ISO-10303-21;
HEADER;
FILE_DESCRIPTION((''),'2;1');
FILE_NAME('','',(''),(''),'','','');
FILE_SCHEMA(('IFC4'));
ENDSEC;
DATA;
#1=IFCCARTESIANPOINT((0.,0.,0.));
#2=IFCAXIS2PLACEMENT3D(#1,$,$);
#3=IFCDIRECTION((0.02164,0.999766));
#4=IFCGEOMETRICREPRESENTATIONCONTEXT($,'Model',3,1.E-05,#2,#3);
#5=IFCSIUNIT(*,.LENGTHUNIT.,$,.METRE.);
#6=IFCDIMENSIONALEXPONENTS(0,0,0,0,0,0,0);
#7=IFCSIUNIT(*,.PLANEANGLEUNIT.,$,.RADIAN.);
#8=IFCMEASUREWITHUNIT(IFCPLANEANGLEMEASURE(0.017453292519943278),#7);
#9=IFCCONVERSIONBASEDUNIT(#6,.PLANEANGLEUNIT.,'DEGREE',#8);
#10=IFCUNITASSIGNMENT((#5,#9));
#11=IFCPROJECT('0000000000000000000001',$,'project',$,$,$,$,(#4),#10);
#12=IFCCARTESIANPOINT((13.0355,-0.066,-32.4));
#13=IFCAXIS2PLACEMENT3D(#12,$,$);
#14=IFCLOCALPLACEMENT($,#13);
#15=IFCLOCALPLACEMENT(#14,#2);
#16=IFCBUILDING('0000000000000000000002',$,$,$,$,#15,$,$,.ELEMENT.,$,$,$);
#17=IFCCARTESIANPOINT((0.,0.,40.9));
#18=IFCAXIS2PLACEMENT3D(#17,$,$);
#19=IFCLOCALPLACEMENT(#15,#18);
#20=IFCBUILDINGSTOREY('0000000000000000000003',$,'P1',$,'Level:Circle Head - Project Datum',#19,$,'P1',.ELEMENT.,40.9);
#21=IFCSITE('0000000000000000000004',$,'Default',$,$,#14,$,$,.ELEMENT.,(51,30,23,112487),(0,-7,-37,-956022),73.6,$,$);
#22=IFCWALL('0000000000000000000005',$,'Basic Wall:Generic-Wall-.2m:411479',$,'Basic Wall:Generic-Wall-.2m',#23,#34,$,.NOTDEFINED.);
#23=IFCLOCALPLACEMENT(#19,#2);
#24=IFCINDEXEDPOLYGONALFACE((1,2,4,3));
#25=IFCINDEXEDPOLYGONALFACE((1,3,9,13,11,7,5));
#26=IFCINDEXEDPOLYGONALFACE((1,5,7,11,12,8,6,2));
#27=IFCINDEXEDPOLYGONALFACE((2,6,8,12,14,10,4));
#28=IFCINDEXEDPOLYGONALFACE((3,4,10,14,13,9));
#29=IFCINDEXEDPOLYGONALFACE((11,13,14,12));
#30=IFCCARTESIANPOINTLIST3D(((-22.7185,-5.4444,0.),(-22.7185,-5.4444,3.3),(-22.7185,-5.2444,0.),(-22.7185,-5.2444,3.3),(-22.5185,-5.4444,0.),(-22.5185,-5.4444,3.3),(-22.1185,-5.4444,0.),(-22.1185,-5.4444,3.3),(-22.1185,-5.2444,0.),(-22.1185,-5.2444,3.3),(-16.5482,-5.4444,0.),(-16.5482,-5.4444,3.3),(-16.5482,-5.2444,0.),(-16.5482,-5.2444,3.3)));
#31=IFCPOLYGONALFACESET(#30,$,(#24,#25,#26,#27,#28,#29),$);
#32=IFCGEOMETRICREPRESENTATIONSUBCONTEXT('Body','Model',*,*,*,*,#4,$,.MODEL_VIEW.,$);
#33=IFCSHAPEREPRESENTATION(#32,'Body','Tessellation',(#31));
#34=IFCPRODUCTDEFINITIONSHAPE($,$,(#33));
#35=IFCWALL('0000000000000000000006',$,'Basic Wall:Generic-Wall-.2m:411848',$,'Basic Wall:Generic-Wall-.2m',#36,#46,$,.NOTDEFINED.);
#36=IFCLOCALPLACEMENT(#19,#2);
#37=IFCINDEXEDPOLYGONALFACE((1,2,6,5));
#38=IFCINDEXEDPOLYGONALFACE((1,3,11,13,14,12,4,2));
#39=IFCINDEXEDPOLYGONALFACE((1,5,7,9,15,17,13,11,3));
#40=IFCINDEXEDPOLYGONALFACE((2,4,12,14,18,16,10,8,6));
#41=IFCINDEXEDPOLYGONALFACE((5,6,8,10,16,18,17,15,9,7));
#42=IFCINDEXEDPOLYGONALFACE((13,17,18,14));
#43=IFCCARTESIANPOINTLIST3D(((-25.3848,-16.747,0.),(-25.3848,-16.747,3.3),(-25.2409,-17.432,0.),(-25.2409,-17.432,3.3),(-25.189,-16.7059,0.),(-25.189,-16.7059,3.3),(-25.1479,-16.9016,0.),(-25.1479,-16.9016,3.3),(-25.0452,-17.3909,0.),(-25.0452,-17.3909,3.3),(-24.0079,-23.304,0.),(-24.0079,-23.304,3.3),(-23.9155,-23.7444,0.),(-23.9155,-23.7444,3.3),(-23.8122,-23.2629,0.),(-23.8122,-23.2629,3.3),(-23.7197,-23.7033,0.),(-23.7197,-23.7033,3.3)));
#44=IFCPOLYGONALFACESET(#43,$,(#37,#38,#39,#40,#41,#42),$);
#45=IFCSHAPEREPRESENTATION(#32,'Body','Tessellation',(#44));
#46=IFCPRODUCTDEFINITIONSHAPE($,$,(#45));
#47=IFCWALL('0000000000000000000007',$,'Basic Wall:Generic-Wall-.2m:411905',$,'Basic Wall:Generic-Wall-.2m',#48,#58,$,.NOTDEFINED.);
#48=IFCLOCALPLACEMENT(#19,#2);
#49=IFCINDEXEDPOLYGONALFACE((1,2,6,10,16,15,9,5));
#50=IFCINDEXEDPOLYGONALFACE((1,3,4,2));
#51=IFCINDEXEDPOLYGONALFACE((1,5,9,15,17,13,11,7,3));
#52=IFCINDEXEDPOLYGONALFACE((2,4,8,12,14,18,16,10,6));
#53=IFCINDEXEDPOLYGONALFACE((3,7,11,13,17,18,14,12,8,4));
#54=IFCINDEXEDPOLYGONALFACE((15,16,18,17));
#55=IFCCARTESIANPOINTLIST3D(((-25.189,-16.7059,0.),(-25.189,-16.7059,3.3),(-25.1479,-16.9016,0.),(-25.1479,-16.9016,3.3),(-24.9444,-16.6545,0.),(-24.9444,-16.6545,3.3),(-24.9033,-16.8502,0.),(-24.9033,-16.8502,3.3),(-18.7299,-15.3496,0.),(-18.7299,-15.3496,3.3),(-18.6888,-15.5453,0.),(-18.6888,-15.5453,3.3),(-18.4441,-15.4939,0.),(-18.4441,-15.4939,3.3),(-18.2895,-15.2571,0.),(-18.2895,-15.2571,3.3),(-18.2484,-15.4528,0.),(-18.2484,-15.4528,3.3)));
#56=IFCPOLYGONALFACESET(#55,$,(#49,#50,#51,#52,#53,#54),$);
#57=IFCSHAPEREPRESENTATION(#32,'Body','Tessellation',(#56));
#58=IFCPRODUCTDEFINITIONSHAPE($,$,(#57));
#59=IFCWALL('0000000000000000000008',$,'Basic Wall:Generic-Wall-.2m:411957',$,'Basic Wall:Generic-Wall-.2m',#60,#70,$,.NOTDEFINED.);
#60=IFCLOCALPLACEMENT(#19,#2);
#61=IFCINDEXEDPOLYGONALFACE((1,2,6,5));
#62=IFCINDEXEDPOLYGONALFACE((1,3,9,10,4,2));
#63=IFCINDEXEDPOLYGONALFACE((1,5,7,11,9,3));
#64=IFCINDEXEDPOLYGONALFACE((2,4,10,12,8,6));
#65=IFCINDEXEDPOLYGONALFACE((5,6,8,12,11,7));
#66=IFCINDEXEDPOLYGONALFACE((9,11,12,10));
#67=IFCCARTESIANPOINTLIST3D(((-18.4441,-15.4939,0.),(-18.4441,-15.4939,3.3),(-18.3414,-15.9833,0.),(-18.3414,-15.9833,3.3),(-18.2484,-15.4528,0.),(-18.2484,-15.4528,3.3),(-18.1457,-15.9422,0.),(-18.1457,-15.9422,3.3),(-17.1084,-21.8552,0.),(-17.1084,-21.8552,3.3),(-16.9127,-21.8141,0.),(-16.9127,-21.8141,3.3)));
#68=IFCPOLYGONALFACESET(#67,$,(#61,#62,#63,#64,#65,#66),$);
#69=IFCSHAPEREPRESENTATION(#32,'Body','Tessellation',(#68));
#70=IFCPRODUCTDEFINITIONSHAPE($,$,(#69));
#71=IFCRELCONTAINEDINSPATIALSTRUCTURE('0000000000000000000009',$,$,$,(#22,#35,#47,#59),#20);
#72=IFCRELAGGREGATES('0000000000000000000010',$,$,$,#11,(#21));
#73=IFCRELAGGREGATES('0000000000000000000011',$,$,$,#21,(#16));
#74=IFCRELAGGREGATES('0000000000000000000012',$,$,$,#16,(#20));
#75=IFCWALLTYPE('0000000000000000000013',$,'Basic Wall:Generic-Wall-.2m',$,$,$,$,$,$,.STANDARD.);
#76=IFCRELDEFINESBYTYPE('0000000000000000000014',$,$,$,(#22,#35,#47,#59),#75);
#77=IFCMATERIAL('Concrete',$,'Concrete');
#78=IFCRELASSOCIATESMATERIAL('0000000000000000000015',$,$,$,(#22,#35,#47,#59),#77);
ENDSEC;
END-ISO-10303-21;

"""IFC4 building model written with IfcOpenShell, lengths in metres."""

from ifc_helpers import new_model, entity, si_unit, converted_unit, direction, frame, origin, place, context, subcontext, project, spatial, indexed_curve, outline, extrude, material, type_object, element, save


model = new_model("IFC4")

# Units and contexts
model_context = context("Model", 3, precision=1e-05, world=origin(), true_north=direction((0.02164, 0.999766)))
body_context = subcontext(model_context, "Body", "Model", "MODEL_VIEW")
ifc_project = project(units=[si_unit("LENGTHUNIT", "METRE"), converted_unit("PLANEANGLEUNIT", "DEGREE", entity("IfcPlaneAngleMeasure", 0.017453292519943278), si_unit("PLANEANGLEUNIT", "RADIAN"), dimensions=[0, 0, 0, 0, 0, 0, 0])], contexts=[model_context])

# Site, building, storey
site_placement = place(None, frame((13.0355, -0.066, -32.4)))
site = spatial("IfcSite", under=ifc_project, at=site_placement, Name="Default", CompositionType="ELEMENT", RefLatitude=(51, 30, 23, 112487), RefLongitude=(0, -7, -37, -956022), RefElevation=73.6)
building_placement = place(site_placement, origin())
building = spatial("IfcBuilding", under=site, at=building_placement, CompositionType="ELEMENT")
storey_placement = place(building_placement, frame((0.0, 0.0, 40.9)))
storey = spatial("IfcBuildingStorey", under=building, at=storey_placement, Name="P1", ObjectType="Level:Circle Head - Project Datum", LongName="P1", CompositionType="ELEMENT", Elevation=40.9)

# Shared definitions
ifc_material = material(Name="Concrete", Category="Concrete")

# Walls
wall_type_1 = type_object("IfcWallType", Name="Basic Wall:Generic-Wall-.2m", PredefinedType="STANDARD")
wall_1_placement = place(storey_placement, frame((-22.7185, -5.3444, 0.0)))
element("IfcWall", 1, at=wall_1_placement, inside=storey, type_object=wall_type_1, material=ifc_material, Name="Basic Wall:Generic-Wall-.2m:411479", ObjectType="Basic Wall:Generic-Wall-.2m", PredefinedType="NOTDEFINED", context=body_context, shape_type="SweptSolid", body=[
    extrude(outline(indexed_curve([(6.1702, -0.1), (6.1702, 0.1), (0.6, 0.1), (0.0, 0.1), (0.0, -0.1), (0.2, -0.1), (0.6, -0.1), (6.1702, -0.1)], self_intersect=False)), origin(), (0.0, 0.0, 1.0), 3.3),
])
wall_2_placement = place(storey_placement, frame((-23.8176, -23.7238, 0.0), z_axis=(0.0, 0.0, 1.0), x_axis=(-0.2055, 0.978657, 0.0)))
element("IfcWall", 2, at=wall_2_placement, inside=storey, type_object=wall_type_1, material=ifc_material, Name="Basic Wall:Generic-Wall-.2m:411848", ObjectType="Basic Wall:Generic-Wall-.2m", PredefinedType="NOTDEFINED", context=body_context, shape_type="SweptSolid", body=[
    extrude(outline(indexed_curve([(7.15, -0.1), (7.15, 0.1), (6.45, 0.1), (0.45, 0.1), (0.0, 0.1), (0.0, -0.1), (0.45, -0.1), (6.45, -0.1), (6.95, -0.1), (7.15, -0.1)], self_intersect=False)), origin(), (0.0, 0.0, 1.0), 3.3),
])
wall_3_placement = place(storey_placement, frame((-25.1685, -16.8038, 0.0), z_axis=(0.0, 0.0, 1.0), x_axis=(0.978657, 0.2055, 0.0)))
element("IfcWall", 3, at=wall_3_placement, inside=storey, type_object=wall_type_1, material=ifc_material, Name="Basic Wall:Generic-Wall-.2m:411905", ObjectType="Basic Wall:Generic-Wall-.2m", PredefinedType="NOTDEFINED", context=body_context, shape_type="SweptSolid", body=[
    extrude(outline(indexed_curve([(7.05, -0.1), (7.05, 0.1), (6.6, 0.1), (0.25, 0.1), (0.0, 0.1), (0.0, -0.1), (0.25, -0.1), (6.6, -0.1), (6.85, -0.1), (7.05, -0.1)], self_intersect=False)), origin(), (0.0, 0.0, 1.0), 3.3),
])
wall_4_placement = place(storey_placement, frame((-18.3463, -15.4734, 0.0), z_axis=(0.0, 0.0, 1.0), x_axis=(0.2055, -0.978657, 0.0)))
element("IfcWall", 4, at=wall_4_placement, inside=storey, type_object=wall_type_1, material=ifc_material, Name="Basic Wall:Generic-Wall-.2m:411957", ObjectType="Basic Wall:Generic-Wall-.2m", PredefinedType="NOTDEFINED", context=body_context, shape_type="SweptSolid", body=[
    extrude(outline(indexed_curve([(6.5, -0.1), (6.5, 0.1), (0.5, 0.1), (0.0, 0.1), (0.0, -0.1), (0.5, -0.1), (6.5, -0.1)], self_intersect=False)), origin(), (0.0, 0.0, 1.0), 3.3),
])

save(model, "model.ifc")
